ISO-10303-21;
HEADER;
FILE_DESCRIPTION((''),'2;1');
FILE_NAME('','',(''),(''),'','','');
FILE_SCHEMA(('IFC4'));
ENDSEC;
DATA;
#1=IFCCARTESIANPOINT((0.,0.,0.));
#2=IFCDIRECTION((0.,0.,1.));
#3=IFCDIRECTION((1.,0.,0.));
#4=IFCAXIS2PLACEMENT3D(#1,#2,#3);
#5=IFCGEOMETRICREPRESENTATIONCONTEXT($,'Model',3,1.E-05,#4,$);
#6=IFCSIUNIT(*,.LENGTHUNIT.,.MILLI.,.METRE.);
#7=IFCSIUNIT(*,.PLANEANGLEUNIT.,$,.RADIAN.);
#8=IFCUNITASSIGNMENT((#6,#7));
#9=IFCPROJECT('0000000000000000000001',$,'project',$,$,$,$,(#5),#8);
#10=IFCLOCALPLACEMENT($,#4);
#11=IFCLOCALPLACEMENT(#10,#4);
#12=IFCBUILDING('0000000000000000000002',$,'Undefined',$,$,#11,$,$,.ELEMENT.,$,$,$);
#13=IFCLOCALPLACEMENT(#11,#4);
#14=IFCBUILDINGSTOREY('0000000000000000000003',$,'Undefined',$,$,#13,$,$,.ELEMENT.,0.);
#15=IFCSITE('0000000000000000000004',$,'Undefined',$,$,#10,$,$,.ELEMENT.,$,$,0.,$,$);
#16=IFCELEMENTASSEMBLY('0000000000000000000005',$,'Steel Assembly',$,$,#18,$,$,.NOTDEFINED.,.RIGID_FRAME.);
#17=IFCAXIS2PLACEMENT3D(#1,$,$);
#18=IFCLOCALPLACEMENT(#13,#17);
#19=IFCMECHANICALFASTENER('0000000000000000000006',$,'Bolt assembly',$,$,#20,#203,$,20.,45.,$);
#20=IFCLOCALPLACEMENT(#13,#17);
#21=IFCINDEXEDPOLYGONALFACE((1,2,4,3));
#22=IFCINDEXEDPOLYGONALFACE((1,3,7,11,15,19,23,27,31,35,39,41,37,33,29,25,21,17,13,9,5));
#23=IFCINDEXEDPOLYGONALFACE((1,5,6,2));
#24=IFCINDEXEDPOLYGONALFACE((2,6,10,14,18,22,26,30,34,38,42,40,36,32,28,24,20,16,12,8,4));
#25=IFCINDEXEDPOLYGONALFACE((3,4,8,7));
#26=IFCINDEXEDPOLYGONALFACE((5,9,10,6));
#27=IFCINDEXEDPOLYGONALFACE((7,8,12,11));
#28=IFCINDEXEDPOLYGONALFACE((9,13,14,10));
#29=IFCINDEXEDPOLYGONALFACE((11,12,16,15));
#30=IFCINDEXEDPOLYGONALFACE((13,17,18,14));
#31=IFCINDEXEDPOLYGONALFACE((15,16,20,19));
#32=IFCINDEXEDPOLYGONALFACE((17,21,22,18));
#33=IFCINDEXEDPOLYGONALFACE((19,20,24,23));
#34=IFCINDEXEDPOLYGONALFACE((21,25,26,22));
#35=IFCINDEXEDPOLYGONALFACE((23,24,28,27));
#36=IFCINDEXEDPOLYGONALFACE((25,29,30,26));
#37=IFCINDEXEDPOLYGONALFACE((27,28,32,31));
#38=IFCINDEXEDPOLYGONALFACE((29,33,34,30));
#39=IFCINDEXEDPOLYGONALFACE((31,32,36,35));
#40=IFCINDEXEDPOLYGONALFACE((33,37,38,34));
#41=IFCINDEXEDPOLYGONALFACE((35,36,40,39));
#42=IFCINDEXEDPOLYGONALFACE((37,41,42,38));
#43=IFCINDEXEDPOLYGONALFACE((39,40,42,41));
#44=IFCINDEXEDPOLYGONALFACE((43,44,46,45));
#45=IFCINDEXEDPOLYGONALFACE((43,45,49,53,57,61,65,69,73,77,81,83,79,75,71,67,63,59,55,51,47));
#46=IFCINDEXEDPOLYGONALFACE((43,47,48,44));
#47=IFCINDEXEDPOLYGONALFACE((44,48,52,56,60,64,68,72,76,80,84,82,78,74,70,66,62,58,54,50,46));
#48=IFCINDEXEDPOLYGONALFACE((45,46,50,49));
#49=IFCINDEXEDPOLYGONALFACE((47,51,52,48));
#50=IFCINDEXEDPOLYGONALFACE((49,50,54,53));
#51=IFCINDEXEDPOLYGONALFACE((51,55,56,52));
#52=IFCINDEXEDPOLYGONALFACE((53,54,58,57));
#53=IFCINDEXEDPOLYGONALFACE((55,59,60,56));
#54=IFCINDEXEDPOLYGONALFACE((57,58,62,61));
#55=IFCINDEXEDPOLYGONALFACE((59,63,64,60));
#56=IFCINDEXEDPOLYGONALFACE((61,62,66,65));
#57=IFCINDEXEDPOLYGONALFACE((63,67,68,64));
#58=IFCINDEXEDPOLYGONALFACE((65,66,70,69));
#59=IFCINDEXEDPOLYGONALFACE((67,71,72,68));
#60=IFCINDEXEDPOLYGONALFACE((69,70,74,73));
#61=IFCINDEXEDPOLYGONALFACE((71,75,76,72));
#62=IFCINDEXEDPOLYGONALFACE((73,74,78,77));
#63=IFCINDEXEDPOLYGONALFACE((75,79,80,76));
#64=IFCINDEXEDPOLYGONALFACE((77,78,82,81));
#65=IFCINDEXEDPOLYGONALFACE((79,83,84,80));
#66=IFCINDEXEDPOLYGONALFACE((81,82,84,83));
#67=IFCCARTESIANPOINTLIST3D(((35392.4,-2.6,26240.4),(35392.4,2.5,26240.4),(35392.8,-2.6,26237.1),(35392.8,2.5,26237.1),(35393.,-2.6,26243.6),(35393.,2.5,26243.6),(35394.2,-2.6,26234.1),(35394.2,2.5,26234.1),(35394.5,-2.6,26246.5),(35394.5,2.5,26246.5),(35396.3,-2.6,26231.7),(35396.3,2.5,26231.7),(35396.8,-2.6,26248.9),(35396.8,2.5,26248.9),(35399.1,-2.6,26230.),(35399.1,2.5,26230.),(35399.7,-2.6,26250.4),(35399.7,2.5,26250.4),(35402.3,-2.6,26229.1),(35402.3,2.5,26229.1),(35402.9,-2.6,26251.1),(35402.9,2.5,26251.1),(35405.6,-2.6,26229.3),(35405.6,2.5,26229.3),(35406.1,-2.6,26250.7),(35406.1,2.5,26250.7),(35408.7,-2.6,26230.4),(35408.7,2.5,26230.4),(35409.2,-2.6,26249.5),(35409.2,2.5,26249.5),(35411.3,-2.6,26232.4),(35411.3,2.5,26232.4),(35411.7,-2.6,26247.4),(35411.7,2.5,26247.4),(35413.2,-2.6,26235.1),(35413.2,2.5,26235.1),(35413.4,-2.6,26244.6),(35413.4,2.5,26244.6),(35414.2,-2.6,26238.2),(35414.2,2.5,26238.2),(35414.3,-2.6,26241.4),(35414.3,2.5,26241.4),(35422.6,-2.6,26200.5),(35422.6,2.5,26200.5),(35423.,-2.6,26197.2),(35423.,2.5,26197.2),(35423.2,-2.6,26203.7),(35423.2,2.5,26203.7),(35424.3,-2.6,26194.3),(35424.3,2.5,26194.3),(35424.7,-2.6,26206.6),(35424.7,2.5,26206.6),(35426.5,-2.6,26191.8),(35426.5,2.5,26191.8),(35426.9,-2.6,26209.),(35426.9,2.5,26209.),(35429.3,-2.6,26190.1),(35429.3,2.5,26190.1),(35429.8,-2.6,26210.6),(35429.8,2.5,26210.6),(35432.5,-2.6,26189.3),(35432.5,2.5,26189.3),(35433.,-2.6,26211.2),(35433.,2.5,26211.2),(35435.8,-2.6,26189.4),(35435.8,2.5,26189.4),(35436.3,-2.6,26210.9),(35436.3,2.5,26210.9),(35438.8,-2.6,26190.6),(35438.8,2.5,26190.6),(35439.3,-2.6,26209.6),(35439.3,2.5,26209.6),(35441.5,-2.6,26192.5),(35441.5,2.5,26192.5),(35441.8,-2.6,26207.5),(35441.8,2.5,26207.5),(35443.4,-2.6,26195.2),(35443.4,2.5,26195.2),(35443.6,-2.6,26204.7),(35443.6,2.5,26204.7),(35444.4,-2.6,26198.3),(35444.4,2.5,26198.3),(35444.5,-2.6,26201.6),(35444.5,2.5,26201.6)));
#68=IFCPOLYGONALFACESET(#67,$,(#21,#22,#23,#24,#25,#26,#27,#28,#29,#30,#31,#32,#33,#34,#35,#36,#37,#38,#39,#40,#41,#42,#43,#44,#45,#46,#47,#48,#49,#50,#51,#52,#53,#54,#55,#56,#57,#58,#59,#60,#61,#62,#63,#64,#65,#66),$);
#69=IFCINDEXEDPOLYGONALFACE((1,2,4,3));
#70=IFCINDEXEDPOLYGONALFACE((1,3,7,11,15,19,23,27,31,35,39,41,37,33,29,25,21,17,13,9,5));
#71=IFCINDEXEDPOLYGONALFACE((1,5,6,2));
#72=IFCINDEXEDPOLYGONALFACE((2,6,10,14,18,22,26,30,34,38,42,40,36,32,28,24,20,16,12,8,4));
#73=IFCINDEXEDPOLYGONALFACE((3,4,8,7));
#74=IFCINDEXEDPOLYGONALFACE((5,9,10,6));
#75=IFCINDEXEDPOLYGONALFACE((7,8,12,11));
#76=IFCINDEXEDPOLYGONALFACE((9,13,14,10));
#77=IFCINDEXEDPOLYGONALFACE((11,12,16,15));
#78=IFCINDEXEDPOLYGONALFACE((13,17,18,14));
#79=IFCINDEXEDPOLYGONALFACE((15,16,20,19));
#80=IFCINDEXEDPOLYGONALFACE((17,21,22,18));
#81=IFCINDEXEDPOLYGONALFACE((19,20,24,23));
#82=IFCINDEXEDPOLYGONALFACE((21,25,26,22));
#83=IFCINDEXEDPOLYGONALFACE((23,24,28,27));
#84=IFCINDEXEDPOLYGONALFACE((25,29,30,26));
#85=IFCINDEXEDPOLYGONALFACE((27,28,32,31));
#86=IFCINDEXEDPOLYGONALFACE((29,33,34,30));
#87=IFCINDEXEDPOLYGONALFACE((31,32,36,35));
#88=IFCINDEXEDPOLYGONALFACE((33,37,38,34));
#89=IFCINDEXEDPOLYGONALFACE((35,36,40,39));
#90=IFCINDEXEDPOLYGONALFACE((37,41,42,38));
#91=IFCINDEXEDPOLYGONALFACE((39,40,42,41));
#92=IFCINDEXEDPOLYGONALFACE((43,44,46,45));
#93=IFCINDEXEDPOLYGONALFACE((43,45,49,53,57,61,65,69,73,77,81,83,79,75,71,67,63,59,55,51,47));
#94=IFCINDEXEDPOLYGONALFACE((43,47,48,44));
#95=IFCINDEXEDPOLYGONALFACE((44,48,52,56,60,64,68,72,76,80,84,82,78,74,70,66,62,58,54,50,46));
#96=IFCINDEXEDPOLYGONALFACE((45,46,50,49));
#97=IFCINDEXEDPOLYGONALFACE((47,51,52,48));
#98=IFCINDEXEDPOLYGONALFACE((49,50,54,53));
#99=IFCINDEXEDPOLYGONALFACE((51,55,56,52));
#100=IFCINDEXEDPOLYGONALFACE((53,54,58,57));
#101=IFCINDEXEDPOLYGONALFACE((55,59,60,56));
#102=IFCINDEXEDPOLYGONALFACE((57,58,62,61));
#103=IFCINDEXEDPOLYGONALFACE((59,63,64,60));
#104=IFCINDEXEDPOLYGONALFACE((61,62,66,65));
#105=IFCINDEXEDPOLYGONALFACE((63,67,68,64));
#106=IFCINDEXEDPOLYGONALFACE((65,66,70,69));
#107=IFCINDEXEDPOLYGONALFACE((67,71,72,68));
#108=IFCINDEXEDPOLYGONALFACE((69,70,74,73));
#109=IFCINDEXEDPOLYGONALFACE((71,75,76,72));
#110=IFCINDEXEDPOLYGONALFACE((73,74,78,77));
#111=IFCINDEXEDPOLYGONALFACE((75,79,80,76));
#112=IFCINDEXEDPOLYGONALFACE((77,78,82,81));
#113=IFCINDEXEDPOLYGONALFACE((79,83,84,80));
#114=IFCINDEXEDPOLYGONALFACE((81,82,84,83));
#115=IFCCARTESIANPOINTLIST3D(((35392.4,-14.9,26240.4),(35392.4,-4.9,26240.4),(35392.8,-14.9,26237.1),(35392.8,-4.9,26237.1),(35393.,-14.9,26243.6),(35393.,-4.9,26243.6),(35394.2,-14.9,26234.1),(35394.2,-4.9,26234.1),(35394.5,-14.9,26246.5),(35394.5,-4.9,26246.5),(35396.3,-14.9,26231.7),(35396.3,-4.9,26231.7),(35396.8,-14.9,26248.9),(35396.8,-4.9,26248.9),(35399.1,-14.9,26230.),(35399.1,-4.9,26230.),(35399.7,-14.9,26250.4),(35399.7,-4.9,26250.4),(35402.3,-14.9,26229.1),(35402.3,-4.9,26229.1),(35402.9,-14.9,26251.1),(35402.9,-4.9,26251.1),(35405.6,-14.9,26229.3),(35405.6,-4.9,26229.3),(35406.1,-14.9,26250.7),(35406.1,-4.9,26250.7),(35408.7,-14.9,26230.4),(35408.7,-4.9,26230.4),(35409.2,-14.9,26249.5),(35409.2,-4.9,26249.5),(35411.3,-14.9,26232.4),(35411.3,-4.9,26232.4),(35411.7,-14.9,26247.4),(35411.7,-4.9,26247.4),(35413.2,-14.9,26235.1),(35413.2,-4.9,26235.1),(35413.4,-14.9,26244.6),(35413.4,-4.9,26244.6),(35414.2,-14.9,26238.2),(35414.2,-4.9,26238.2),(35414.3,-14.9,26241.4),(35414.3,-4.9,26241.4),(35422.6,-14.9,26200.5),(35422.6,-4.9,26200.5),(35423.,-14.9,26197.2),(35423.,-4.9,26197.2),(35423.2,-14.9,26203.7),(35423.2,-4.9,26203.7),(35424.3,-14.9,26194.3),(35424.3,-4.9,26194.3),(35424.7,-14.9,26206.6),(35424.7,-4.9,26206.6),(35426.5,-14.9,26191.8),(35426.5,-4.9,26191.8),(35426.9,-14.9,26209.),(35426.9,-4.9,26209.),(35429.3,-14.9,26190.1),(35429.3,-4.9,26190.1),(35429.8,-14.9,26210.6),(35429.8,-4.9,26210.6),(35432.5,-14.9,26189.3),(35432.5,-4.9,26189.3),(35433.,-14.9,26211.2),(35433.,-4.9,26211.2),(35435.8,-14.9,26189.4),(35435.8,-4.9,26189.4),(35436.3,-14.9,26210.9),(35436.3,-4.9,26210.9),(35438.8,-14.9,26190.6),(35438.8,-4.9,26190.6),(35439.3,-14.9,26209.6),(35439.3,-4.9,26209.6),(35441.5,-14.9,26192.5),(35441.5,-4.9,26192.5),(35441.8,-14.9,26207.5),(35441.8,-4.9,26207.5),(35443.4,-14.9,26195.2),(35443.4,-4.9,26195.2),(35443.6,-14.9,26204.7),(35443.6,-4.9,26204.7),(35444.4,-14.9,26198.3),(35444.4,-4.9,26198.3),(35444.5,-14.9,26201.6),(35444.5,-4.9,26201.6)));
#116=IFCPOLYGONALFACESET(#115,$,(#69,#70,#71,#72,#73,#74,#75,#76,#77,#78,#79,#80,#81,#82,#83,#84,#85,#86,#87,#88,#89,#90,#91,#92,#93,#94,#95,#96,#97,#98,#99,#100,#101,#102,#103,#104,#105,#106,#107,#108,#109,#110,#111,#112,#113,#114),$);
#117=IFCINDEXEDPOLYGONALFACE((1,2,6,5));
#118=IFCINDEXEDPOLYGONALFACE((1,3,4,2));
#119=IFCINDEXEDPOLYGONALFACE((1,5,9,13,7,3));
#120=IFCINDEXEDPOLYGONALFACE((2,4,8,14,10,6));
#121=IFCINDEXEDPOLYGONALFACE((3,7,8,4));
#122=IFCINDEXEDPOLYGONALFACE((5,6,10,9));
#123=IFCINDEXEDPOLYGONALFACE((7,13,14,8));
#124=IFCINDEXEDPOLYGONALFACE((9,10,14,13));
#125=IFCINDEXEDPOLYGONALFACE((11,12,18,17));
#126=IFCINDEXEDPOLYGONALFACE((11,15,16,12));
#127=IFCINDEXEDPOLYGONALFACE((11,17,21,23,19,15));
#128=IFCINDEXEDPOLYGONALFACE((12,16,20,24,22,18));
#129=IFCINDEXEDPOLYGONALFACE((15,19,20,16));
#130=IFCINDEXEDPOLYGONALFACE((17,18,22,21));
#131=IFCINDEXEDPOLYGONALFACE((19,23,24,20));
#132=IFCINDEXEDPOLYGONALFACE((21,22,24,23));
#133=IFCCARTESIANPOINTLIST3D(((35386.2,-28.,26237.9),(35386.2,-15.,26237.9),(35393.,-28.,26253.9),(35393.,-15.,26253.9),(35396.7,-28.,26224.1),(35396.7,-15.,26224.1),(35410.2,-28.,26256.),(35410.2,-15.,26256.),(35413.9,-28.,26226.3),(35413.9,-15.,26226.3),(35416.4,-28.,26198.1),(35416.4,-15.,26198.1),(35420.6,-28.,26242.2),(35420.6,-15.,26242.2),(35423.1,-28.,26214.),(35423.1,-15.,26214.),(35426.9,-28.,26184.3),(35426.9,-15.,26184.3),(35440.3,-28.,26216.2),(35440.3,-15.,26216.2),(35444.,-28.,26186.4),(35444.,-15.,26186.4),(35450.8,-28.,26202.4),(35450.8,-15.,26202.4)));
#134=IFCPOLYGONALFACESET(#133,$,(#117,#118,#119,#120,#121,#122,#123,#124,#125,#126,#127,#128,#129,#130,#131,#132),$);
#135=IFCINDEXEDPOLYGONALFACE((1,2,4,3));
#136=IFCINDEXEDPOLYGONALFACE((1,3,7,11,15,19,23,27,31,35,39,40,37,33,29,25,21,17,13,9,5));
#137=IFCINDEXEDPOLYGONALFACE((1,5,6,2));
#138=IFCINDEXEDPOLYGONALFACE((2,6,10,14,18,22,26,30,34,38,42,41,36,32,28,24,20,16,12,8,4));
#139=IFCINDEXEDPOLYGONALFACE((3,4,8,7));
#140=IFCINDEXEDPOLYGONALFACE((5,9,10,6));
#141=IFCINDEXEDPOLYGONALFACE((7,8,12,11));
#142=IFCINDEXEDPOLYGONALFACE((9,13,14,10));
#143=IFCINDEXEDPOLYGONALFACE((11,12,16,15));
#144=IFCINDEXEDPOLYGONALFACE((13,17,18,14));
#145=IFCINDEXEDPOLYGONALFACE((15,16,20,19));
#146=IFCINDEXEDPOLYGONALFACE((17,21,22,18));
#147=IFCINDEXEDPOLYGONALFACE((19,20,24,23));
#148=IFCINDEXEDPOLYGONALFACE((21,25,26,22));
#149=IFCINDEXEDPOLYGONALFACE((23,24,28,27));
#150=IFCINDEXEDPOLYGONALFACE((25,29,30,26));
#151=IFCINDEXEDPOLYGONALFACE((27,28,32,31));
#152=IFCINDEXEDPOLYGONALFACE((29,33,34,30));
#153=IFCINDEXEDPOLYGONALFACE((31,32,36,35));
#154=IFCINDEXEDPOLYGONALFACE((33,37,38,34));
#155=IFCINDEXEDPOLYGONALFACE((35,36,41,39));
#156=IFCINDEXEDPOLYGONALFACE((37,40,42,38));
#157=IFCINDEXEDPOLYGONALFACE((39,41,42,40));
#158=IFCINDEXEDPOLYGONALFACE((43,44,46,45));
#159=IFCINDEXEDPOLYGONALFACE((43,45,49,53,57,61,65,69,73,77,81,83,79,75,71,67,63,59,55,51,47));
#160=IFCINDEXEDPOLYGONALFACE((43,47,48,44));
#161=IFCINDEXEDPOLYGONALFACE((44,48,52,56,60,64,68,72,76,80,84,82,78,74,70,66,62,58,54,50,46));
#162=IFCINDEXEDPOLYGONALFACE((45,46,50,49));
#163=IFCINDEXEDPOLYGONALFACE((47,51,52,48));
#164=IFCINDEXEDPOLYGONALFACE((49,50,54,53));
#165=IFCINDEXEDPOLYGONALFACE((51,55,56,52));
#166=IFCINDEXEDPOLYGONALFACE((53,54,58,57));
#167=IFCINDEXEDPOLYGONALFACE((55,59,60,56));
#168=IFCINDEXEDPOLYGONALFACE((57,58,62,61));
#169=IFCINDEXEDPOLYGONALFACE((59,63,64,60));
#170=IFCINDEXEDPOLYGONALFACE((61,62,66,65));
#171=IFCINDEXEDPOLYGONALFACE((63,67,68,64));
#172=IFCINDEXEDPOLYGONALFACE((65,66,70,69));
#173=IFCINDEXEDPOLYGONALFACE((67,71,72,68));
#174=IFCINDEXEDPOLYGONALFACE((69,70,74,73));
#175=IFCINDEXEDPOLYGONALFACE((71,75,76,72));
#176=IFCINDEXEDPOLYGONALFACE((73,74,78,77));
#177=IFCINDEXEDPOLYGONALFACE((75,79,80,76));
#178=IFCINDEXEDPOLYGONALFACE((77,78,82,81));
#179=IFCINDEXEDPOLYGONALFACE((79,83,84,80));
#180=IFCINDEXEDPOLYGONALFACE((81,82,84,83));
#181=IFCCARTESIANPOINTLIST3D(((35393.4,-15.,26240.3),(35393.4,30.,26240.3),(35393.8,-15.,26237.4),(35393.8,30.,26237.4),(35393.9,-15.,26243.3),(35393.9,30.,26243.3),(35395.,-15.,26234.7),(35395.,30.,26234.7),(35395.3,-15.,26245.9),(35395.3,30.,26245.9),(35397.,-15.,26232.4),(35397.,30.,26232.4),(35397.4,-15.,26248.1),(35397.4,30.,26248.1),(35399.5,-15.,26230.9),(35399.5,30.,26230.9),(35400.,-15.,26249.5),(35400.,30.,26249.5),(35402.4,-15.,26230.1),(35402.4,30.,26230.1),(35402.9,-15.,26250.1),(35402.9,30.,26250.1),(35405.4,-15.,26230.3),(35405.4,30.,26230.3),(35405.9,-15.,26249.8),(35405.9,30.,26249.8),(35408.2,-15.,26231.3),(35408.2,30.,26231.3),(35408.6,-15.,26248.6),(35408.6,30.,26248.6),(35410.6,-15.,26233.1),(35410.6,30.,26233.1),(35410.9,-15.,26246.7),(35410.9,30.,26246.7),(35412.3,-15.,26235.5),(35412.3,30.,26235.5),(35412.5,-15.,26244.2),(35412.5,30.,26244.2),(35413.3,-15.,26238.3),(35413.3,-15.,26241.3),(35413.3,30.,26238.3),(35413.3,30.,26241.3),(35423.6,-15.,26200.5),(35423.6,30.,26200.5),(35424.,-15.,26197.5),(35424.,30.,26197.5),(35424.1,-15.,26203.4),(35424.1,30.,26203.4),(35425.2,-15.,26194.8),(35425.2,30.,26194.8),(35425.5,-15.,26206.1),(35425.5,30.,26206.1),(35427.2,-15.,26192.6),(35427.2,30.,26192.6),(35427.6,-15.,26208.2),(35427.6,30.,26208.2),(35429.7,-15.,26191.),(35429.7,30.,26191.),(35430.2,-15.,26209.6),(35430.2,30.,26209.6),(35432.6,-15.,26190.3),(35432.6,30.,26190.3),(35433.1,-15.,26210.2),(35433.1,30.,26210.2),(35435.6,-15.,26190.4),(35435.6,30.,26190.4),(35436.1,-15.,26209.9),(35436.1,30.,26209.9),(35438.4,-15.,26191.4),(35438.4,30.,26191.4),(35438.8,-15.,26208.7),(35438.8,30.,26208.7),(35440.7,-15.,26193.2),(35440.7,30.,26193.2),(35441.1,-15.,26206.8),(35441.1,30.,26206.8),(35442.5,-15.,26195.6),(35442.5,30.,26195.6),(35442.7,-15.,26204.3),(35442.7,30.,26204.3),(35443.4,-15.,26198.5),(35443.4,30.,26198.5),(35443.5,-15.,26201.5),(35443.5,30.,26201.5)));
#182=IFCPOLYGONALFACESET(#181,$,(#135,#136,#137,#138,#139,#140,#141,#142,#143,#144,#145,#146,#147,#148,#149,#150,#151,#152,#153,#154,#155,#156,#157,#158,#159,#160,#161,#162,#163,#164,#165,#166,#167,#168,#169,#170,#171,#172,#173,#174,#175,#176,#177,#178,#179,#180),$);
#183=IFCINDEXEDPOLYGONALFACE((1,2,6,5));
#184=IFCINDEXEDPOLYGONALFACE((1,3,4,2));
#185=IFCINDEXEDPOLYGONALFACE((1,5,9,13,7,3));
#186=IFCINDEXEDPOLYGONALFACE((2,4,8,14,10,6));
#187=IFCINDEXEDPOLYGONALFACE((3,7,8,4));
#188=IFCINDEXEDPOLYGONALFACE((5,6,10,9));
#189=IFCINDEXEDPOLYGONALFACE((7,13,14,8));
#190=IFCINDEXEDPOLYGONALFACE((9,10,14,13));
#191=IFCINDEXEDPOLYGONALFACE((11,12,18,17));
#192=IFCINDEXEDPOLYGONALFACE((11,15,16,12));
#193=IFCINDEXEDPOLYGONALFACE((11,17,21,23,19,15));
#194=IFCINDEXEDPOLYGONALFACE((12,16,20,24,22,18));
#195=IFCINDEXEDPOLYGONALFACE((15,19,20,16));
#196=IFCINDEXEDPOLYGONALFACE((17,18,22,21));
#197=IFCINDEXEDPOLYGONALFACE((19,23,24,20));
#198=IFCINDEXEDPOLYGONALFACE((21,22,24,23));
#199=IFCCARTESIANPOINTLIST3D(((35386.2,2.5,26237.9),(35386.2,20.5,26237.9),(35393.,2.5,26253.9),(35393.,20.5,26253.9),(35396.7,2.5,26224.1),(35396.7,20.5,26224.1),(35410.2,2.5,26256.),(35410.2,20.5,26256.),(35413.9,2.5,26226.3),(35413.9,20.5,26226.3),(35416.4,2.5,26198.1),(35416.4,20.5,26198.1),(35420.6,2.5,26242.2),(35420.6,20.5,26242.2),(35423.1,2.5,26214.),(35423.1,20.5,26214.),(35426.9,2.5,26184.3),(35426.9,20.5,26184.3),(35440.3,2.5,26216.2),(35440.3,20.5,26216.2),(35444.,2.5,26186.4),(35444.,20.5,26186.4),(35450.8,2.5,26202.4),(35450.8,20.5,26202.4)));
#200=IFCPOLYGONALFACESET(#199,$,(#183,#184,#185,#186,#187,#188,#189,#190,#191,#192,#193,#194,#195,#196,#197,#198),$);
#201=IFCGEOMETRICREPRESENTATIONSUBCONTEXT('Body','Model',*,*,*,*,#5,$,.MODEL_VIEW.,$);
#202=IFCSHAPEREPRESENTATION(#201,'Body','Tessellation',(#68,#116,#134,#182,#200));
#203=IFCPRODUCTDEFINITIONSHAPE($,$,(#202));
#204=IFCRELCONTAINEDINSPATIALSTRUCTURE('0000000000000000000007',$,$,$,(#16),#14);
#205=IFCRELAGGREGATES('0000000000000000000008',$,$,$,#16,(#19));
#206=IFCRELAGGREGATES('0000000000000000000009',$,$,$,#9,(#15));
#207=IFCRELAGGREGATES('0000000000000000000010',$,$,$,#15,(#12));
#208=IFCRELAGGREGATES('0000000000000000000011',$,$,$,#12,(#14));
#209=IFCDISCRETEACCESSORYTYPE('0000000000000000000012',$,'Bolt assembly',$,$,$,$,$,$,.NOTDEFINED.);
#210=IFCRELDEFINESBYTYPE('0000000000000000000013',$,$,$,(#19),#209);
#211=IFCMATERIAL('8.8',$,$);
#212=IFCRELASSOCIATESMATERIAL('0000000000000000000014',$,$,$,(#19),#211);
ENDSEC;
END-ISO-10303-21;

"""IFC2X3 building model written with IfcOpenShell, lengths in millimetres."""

from ifc_helpers import new_model, si_unit, frame, origin_with_axes, origin_2d_with_axis, place, context, subcontext, project, spatial, polyline, circle, outline, extrude, source, transform, mapped, material, type_object, element, aggregate, save


model = new_model("IFC2X3")

# Units and contexts
model_context = context("Model", 3, precision=1e-05, world=origin_with_axes())
body_context = subcontext(model_context, "Body", "Model", "MODEL_VIEW")
ifc_project = project(units=[si_unit("LENGTHUNIT", "METRE", prefix="MILLI"), si_unit("PLANEANGLEUNIT", "RADIAN")], contexts=[model_context])

# Site, building, storey
site_placement = place(None, origin_with_axes())
site = spatial("IfcSite", under=ifc_project, at=site_placement, Name="Undefined", CompositionType="ELEMENT", RefElevation=0.0)
building_placement = place(site_placement, origin_with_axes())
building = spatial("IfcBuilding", under=site, at=building_placement, Name="Undefined", CompositionType="ELEMENT")
storey_placement = place(building_placement, origin_with_axes())
storey = spatial("IfcBuildingStorey", under=building, at=storey_placement, Name="Undefined", CompositionType="ELEMENT", Elevation=0.0)

# Element assembly
assembly_1_placement = place(storey_placement, origin_with_axes())
assembly_1 = element("IfcElementAssembly", 1, at=assembly_1_placement, inside=storey, Name="Steel Assembly", AssemblyPlace="NOTDEFINED", PredefinedType="RIGID_FRAME")

# Shared definitions
discrete_accessory_type_1 = type_object("IfcDiscreteAccessoryType", Name="Bolt assembly")
ifc_material_1 = material(Name="8.8")

# Mechanical fastener
shared_shape_1 = source(origin_with_axes(), body_context, "Body", "SweptSolid", [
    extrude(circle(Radius=11.0, at=origin_2d_with_axis()), frame((0.0, -2.6, 0.0), z_axis=(0.0, 1.0, 0.0), x_axis=(1.0, 0.0, 0.0)), (0.0, 0.0, 1.0), 5.1),
    extrude(circle(Radius=11.0, at=origin_2d_with_axis()), frame((0.0, -14.9, 0.0), z_axis=(0.0, 1.0, 0.0), x_axis=(1.0, 0.0, 0.0)), (0.0, 0.0, 1.0), 10.0),
    extrude(outline(polyline([(17.3, 0.0), (8.7, 15.0), (-8.7, 15.0), (-17.3, 0.0), (-8.7, -15.0), (8.7, -15.0), (17.3, 0.0)])), frame((0.0, -28.0, 0.0), z_axis=(0.0, 1.0, 0.0), x_axis=(1.0, 0.0, 0.0)), (0.0, 0.0, 1.0), 13.0),
    extrude(circle(Radius=10.0, at=origin_2d_with_axis()), frame((0.0, -15.0, 0.0), z_axis=(0.0, 1.0, 0.0), x_axis=(1.0, 0.0, 0.0)), (0.0, 0.0, 1.0), 45.0),
    extrude(outline(polyline([(17.3, 0.0), (8.7, 15.0), (-8.7, 15.0), (-17.3, 0.0), (-8.7, -15.0), (8.7, -15.0), (17.3, 0.0)])), frame((0.0, 2.5, 0.0), z_axis=(0.0, 1.0, 0.0), x_axis=(1.0, 0.0, 0.0)), (0.0, 0.0, 1.0), 18.0),
])
mechanical_fastener_1_placement = place(assembly_1_placement, frame((35433.6, 0.0, 26200.2), z_axis=(-0.797403, 0.0, -0.603447), x_axis=(-0.603447, 0.0, 0.797403)))
mechanical_fastener_1 = element("IfcMechanicalFastener", 2, at=mechanical_fastener_1_placement, type_object=discrete_accessory_type_1, material=ifc_material_1, Name="Bolt assembly", NominalDiameter=20.0, NominalLength=45.0, context=body_context, shape_type="MappedRepresentation", body=[
    mapped(shared_shape_1, transform((0.0, 0.0, 0.0))),
    mapped(shared_shape_1, transform((50.0, 0.0, 0.0))),
])
aggregate(assembly_1, [mechanical_fastener_1])

save(model, "model.ifc")
